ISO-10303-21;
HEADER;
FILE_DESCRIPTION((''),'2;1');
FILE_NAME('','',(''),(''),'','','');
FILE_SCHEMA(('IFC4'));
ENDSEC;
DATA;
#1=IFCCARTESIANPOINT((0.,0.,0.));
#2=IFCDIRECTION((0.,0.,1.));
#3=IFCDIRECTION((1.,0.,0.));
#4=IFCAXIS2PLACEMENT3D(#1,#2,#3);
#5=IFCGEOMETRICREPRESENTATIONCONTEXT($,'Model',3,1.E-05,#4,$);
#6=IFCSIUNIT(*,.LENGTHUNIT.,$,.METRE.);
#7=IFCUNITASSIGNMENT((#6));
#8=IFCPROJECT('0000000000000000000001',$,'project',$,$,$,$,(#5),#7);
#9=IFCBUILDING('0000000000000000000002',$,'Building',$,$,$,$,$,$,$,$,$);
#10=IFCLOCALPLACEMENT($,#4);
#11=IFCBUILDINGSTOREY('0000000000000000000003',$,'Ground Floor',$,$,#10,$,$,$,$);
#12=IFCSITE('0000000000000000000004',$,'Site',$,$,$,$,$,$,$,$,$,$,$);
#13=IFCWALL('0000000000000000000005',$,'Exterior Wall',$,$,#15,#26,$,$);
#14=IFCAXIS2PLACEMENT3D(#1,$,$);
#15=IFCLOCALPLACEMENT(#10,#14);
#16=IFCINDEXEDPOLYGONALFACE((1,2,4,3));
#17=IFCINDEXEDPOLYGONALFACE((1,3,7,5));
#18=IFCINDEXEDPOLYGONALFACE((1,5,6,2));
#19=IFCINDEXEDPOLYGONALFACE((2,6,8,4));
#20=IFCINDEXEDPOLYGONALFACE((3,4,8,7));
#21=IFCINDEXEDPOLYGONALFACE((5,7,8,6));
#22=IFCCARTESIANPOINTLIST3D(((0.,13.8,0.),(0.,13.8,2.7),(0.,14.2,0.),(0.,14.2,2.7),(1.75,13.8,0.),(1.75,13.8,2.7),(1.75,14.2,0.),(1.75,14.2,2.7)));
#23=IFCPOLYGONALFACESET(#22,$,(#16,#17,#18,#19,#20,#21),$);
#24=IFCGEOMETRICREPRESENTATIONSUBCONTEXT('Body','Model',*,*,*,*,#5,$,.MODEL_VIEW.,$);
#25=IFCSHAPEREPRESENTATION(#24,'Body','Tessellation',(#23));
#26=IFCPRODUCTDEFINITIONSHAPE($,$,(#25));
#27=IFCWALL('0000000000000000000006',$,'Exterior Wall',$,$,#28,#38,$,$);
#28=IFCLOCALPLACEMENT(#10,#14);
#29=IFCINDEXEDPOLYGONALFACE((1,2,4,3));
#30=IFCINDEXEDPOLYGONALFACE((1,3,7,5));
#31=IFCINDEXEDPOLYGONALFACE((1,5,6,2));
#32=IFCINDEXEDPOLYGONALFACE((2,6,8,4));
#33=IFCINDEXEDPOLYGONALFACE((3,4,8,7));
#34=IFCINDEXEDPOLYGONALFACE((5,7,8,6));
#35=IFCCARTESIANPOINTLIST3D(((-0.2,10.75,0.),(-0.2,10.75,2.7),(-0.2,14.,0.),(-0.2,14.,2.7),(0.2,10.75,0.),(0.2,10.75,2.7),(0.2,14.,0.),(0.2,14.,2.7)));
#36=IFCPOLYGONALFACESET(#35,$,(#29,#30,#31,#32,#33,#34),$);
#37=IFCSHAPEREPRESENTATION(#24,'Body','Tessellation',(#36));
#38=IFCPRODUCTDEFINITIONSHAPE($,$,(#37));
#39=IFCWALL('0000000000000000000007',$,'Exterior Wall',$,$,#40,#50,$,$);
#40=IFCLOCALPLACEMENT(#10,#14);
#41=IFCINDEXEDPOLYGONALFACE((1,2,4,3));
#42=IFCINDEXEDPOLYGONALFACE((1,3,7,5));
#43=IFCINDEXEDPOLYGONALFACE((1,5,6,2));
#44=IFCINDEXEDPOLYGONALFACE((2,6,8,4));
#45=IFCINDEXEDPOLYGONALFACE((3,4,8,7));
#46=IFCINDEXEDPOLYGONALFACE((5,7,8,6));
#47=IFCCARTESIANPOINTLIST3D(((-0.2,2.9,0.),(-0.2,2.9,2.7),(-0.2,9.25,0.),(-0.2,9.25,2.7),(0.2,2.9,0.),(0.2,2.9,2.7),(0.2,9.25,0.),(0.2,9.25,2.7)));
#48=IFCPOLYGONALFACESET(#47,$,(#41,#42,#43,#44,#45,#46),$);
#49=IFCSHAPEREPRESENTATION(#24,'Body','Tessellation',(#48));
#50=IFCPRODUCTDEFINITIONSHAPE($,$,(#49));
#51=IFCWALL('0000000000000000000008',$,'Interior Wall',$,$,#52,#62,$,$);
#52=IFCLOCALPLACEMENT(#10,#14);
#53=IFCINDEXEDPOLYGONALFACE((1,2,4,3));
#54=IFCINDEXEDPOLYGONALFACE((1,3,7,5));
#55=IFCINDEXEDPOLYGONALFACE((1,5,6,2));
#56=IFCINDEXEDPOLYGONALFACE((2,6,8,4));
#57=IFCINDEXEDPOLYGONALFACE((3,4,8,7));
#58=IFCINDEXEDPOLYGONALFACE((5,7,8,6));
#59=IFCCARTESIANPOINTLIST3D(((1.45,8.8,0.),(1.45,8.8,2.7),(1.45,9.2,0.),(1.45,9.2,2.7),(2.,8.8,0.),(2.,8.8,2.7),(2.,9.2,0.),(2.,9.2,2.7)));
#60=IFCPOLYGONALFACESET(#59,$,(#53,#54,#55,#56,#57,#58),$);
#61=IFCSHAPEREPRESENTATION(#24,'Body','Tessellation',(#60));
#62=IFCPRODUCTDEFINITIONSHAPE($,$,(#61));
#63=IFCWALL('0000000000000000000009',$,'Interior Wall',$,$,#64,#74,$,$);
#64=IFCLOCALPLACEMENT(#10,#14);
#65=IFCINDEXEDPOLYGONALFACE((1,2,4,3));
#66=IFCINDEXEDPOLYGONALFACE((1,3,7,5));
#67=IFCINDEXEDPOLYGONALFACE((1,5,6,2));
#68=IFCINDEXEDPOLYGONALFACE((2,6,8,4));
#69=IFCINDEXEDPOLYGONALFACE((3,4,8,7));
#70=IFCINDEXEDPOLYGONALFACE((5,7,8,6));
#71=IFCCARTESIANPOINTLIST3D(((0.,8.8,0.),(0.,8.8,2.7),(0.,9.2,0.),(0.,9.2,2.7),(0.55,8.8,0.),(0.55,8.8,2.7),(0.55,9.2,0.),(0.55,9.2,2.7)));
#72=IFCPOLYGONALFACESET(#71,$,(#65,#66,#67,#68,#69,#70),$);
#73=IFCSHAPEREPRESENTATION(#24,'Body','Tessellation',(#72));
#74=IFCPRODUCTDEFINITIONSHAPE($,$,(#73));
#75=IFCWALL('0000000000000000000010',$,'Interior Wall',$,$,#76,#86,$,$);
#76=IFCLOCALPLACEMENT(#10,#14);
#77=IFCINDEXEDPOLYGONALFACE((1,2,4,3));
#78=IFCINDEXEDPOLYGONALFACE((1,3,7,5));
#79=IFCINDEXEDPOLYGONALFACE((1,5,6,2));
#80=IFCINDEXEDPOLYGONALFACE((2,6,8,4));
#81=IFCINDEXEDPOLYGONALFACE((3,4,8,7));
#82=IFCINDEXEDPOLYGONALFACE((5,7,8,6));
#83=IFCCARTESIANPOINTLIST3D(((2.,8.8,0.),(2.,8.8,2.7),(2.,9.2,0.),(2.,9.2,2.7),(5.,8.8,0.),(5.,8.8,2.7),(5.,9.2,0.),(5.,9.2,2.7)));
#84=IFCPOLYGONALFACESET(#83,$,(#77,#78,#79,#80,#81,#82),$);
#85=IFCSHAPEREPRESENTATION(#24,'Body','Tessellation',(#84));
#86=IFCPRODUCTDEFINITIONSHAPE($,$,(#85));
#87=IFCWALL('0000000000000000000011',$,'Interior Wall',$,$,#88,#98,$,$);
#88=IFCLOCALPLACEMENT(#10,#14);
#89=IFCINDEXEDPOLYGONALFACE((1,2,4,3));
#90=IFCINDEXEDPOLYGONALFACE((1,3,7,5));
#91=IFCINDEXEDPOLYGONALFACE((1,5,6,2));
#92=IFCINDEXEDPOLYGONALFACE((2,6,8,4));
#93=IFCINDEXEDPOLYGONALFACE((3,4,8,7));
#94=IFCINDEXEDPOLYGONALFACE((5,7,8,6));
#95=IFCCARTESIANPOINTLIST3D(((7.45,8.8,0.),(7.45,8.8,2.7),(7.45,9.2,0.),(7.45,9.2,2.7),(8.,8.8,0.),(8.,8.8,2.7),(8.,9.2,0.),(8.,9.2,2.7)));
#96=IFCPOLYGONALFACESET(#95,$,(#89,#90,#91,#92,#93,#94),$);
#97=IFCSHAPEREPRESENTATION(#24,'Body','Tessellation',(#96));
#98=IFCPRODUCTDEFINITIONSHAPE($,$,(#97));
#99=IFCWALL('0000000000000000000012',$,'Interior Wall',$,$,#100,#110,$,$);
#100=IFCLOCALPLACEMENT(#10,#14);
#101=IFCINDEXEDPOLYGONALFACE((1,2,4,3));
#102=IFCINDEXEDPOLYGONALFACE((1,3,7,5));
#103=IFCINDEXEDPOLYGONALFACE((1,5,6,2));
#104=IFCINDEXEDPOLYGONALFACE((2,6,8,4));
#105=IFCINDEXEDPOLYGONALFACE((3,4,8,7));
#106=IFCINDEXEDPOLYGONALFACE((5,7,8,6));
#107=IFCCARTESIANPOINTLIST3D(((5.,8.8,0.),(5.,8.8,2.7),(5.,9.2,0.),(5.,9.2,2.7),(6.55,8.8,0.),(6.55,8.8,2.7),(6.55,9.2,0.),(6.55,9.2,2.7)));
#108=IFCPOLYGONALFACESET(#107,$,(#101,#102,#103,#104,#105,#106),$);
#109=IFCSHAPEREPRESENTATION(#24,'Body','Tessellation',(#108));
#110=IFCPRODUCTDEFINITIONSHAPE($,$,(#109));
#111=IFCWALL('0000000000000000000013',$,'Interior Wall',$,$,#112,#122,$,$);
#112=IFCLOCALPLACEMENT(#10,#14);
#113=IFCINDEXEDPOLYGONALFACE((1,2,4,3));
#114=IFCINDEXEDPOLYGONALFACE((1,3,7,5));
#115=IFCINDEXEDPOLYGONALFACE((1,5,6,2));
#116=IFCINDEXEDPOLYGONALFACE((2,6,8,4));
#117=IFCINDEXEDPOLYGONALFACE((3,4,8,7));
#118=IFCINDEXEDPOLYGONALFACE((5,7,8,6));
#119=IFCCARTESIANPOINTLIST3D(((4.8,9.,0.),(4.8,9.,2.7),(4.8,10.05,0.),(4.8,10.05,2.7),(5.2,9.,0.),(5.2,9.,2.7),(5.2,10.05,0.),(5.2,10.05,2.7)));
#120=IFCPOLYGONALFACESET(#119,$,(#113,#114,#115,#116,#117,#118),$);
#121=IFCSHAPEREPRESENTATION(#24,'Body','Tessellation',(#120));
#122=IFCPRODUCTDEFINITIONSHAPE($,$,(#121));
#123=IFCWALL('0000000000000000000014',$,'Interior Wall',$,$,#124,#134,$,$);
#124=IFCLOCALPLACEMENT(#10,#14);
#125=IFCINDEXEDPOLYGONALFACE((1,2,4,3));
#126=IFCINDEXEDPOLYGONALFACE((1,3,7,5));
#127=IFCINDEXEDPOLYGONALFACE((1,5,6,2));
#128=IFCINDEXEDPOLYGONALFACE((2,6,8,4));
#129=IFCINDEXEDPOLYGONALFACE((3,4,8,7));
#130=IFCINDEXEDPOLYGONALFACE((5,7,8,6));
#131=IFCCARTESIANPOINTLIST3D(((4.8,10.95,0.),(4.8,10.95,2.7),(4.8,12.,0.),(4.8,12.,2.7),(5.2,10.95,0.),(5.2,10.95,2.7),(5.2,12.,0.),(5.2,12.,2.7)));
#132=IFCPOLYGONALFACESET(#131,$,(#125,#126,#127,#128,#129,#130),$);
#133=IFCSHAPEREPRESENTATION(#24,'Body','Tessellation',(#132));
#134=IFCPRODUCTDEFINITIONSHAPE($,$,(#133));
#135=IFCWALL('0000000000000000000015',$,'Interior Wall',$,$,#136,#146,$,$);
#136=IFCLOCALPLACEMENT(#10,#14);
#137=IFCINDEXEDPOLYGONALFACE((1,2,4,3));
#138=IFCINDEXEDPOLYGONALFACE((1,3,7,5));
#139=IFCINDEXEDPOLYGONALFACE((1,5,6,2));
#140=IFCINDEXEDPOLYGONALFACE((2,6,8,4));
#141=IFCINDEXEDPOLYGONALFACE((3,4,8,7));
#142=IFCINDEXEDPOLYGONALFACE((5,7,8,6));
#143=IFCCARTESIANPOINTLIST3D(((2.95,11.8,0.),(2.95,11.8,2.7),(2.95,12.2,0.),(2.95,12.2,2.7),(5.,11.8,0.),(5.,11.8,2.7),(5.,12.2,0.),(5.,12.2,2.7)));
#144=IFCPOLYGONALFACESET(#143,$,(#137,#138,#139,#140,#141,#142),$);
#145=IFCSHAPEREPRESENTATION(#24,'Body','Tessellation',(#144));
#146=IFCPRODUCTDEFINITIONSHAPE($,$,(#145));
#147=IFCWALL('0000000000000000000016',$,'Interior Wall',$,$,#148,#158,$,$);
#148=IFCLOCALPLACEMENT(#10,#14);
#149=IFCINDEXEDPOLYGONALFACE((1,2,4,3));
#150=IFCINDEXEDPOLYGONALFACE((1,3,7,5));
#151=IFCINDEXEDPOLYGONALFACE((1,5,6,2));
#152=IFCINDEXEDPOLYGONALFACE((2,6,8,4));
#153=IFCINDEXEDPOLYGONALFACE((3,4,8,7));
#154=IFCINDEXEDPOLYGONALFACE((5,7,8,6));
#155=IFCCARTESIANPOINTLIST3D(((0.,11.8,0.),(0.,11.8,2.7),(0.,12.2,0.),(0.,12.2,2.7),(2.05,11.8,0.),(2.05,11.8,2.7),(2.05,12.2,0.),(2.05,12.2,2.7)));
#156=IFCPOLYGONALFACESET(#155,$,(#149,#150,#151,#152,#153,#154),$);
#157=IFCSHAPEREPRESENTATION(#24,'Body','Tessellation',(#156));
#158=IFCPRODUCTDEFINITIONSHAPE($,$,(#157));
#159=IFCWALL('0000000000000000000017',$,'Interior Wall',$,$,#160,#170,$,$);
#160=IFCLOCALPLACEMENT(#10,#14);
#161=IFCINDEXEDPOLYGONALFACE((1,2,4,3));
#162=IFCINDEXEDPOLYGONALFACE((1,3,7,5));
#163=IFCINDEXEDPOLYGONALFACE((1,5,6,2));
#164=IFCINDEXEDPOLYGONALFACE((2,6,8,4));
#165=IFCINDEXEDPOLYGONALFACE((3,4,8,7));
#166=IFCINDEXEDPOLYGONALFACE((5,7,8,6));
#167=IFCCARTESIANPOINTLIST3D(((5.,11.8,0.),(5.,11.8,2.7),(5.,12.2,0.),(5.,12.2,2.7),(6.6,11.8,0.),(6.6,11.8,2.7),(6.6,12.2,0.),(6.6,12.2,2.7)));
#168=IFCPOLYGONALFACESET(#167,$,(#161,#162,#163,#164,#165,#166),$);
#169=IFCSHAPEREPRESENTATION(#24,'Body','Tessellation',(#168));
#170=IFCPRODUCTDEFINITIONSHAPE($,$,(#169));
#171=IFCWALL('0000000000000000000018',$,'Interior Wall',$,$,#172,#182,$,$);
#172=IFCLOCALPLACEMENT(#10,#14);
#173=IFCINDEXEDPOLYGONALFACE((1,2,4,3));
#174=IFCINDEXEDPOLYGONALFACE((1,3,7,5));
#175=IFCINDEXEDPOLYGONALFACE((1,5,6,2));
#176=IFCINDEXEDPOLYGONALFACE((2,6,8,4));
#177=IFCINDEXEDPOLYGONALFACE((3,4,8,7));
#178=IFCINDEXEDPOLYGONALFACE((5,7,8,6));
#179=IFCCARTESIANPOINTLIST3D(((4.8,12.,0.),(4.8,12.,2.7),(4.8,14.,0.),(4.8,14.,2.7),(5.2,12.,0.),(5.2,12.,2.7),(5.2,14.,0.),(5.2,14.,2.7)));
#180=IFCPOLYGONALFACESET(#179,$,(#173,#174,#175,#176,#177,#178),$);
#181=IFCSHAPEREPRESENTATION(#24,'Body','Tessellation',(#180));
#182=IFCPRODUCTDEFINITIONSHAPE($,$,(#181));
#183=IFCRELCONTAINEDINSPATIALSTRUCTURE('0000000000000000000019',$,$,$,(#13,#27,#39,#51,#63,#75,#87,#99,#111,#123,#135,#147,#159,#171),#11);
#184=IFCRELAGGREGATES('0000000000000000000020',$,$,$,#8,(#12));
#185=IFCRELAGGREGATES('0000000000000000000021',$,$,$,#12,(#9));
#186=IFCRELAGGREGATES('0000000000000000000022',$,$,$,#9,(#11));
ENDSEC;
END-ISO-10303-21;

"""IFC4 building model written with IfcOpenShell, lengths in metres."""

from ifc_helpers import new_model, si_unit, frame, origin_with_axes, place, context, subcontext, project, spatial, indexed_curve, outline, extrude, element, save


model = new_model("IFC4")

# Units and contexts
model_context = context("Model", 3, precision=1e-05, world=origin_with_axes())
body_context = subcontext(model_context, "Body", "Model", "MODEL_VIEW")
ifc_project = project(units=[si_unit("LENGTHUNIT", "METRE")], contexts=[model_context])

# Site, building, storey
site = spatial("IfcSite", under=ifc_project, Name="Site")
building = spatial("IfcBuilding", under=site, Name="Building")
storey_placement = place(None, origin_with_axes())
storey = spatial("IfcBuildingStorey", under=building, at=storey_placement, Name="Ground Floor")

# Walls
wall_1_placement = place(storey_placement, frame((1.75, 14.0, 0.0), z_axis=(0.0, 0.0, 1.0), x_axis=(-1.0, 0.0, 0.0)))
element("IfcWall", 1, at=wall_1_placement, inside=storey, Name="Exterior Wall", context=body_context, shape_type="SweptSolid", body=[
    extrude(outline(indexed_curve([(0.0, 0.0), (0.0, 0.4), (1.75, 0.4), (1.75, 0.0), (0.0, 0.0)], self_intersect=False)), frame((0.0, -0.2, 0.0), z_axis=(0.0, 0.0, 1.0), x_axis=(1.0, 0.0, 0.0)), (0.0, 0.0, 1.0), 2.7),
])
wall_2_placement = place(storey_placement, frame((0.0, 14.0, 0.0), z_axis=(0.0, 0.0, 1.0), x_axis=(0.0, -1.0, 0.0)))
element("IfcWall", 2, at=wall_2_placement, inside=storey, Name="Exterior Wall", context=body_context, shape_type="SweptSolid", body=[
    extrude(outline(indexed_curve([(0.0, 0.0), (0.0, 0.4), (3.25, 0.4), (3.25, 0.0), (0.0, 0.0)], self_intersect=False)), frame((0.0, -0.2, 0.0), z_axis=(0.0, 0.0, 1.0), x_axis=(1.0, 0.0, 0.0)), (0.0, 0.0, 1.0), 2.7),
])
wall_3_placement = place(storey_placement, frame((0.0, 9.25, 0.0), z_axis=(0.0, 0.0, 1.0), x_axis=(0.0, -1.0, 0.0)))
element("IfcWall", 3, at=wall_3_placement, inside=storey, Name="Exterior Wall", context=body_context, shape_type="SweptSolid", body=[
    extrude(outline(indexed_curve([(0.0, 0.0), (0.0, 0.4), (6.35, 0.4), (6.35, 0.0), (0.0, 0.0)], self_intersect=False)), frame((0.0, -0.2, 0.0), z_axis=(0.0, 0.0, 1.0), x_axis=(1.0, 0.0, 0.0)), (0.0, 0.0, 1.0), 2.7),
])
for number, where, z_axis, x_axis, name in (
    (4, (2.0, 9.0, 0.0), (0.0, 0.0, 1.0), (-1.0, 0.0, 0.0), "Interior Wall"),
    (5, (0.55, 9.0, 0.0), (0.0, 0.0, 1.0), (-1.0, 0.0, 0.0), "Interior Wall"),
):
    element("IfcWall", number, at=place(storey_placement, frame(where, z_axis=z_axis, x_axis=x_axis)), inside=storey, Name=name, context=body_context, shape_type="SweptSolid", body=[
        extrude(outline(indexed_curve([(0.0, 0.0), (0.0, 0.4), (0.55, 0.4), (0.55, 0.0), (0.0, 0.0)], self_intersect=False)), frame((0.0, -0.2, 0.0), z_axis=(0.0, 0.0, 1.0), x_axis=(1.0, 0.0, 0.0)), (0.0, 0.0, 1.0), 2.7),
    ])
wall_4_placement = place(storey_placement, frame((5.0, 9.0, 0.0), z_axis=(0.0, 0.0, 1.0), x_axis=(-1.0, 0.0, 0.0)))
element("IfcWall", 6, at=wall_4_placement, inside=storey, Name="Interior Wall", context=body_context, shape_type="SweptSolid", body=[
    extrude(outline(indexed_curve([(0.0, 0.0), (0.0, 0.4), (3.0, 0.4), (3.0, 0.0), (0.0, 0.0)], self_intersect=False)), frame((0.0, -0.2, 0.0), z_axis=(0.0, 0.0, 1.0), x_axis=(1.0, 0.0, 0.0)), (0.0, 0.0, 1.0), 2.7),
])
wall_5_placement = place(storey_placement, frame((8.0, 9.0, 0.0), z_axis=(0.0, 0.0, 1.0), x_axis=(-1.0, 0.0, 0.0)))
element("IfcWall", 7, at=wall_5_placement, inside=storey, Name="Interior Wall", context=body_context, shape_type="SweptSolid", body=[
    extrude(outline(indexed_curve([(0.0, 0.0), (0.0, 0.4), (0.55, 0.4), (0.55, 0.0), (0.0, 0.0)], self_intersect=False)), frame((0.0, -0.2, 0.0), z_axis=(0.0, 0.0, 1.0), x_axis=(1.0, 0.0, 0.0)), (0.0, 0.0, 1.0), 2.7),
])
wall_6_placement = place(storey_placement, frame((6.55, 9.0, 0.0), z_axis=(0.0, 0.0, 1.0), x_axis=(-1.0, 0.0, 0.0)))
element("IfcWall", 8, at=wall_6_placement, inside=storey, Name="Interior Wall", context=body_context, shape_type="SweptSolid", body=[
    extrude(outline(indexed_curve([(0.0, 0.0), (0.0, 0.4), (1.55, 0.4), (1.55, 0.0), (0.0, 0.0)], self_intersect=False)), frame((0.0, -0.2, 0.0), z_axis=(0.0, 0.0, 1.0), x_axis=(1.0, 0.0, 0.0)), (0.0, 0.0, 1.0), 2.7),
])
for number, where, z_axis, x_axis, name in (
    (9, (5.0, 9.0, 0.0), (0.0, 0.0, 1.0), (0.0, 1.0, 0.0), "Interior Wall"),
    (10, (5.0, 10.95, 0.0), (0.0, 0.0, 1.0), (0.0, 1.0, 0.0), "Interior Wall"),
):
    element("IfcWall", number, at=place(storey_placement, frame(where, z_axis=z_axis, x_axis=x_axis)), inside=storey, Name=name, context=body_context, shape_type="SweptSolid", body=[
        extrude(outline(indexed_curve([(0.0, 0.0), (0.0, 0.4), (1.05, 0.4), (1.05, 0.0), (0.0, 0.0)], self_intersect=False)), frame((0.0, -0.2, 0.0), z_axis=(0.0, 0.0, 1.0), x_axis=(1.0, 0.0, 0.0)), (0.0, 0.0, 1.0), 2.7),
    ])
for number, where, z_axis, x_axis, name in (
    (11, (5.0, 12.0, 0.0), (0.0, 0.0, 1.0), (-1.0, 0.0, 0.0), "Interior Wall"),
    (12, (2.05, 12.0, 0.0), (0.0, 0.0, 1.0), (-1.0, 0.0, 0.0), "Interior Wall"),
):
    element("IfcWall", number, at=place(storey_placement, frame(where, z_axis=z_axis, x_axis=x_axis)), inside=storey, Name=name, context=body_context, shape_type="SweptSolid", body=[
        extrude(outline(indexed_curve([(0.0, 0.0), (0.0, 0.4), (2.05, 0.4), (2.05, 0.0), (0.0, 0.0)], self_intersect=False)), frame((0.0, -0.2, 0.0), z_axis=(0.0, 0.0, 1.0), x_axis=(1.0, 0.0, 0.0)), (0.0, 0.0, 1.0), 2.7),
    ])
wall_7_placement = place(storey_placement, frame((6.6, 12.0, 0.0), z_axis=(0.0, 0.0, 1.0), x_axis=(-1.0, 0.0, 0.0)))
element("IfcWall", 13, at=wall_7_placement, inside=storey, Name="Interior Wall", context=body_context, shape_type="SweptSolid", body=[
    extrude(outline(indexed_curve([(0.0, 0.0), (0.0, 0.4), (1.6, 0.4), (1.6, 0.0), (0.0, 0.0)], self_intersect=False)), frame((0.0, -0.2, 0.0), z_axis=(0.0, 0.0, 1.0), x_axis=(1.0, 0.0, 0.0)), (0.0, 0.0, 1.0), 2.7),
])
wall_8_placement = place(storey_placement, frame((5.0, 14.0, 0.0), z_axis=(0.0, 0.0, 1.0), x_axis=(0.0, -1.0, 0.0)))
element("IfcWall", 14, at=wall_8_placement, inside=storey, Name="Interior Wall", context=body_context, shape_type="SweptSolid", body=[
    extrude(outline(indexed_curve([(0.0, 0.0), (0.0, 0.4), (2.0, 0.4), (2.0, 0.0), (0.0, 0.0)], self_intersect=False)), frame((0.0, -0.2, 0.0), z_axis=(0.0, 0.0, 1.0), x_axis=(1.0, 0.0, 0.0)), (0.0, 0.0, 1.0), 2.7),
])

save(model, "model.ifc")
